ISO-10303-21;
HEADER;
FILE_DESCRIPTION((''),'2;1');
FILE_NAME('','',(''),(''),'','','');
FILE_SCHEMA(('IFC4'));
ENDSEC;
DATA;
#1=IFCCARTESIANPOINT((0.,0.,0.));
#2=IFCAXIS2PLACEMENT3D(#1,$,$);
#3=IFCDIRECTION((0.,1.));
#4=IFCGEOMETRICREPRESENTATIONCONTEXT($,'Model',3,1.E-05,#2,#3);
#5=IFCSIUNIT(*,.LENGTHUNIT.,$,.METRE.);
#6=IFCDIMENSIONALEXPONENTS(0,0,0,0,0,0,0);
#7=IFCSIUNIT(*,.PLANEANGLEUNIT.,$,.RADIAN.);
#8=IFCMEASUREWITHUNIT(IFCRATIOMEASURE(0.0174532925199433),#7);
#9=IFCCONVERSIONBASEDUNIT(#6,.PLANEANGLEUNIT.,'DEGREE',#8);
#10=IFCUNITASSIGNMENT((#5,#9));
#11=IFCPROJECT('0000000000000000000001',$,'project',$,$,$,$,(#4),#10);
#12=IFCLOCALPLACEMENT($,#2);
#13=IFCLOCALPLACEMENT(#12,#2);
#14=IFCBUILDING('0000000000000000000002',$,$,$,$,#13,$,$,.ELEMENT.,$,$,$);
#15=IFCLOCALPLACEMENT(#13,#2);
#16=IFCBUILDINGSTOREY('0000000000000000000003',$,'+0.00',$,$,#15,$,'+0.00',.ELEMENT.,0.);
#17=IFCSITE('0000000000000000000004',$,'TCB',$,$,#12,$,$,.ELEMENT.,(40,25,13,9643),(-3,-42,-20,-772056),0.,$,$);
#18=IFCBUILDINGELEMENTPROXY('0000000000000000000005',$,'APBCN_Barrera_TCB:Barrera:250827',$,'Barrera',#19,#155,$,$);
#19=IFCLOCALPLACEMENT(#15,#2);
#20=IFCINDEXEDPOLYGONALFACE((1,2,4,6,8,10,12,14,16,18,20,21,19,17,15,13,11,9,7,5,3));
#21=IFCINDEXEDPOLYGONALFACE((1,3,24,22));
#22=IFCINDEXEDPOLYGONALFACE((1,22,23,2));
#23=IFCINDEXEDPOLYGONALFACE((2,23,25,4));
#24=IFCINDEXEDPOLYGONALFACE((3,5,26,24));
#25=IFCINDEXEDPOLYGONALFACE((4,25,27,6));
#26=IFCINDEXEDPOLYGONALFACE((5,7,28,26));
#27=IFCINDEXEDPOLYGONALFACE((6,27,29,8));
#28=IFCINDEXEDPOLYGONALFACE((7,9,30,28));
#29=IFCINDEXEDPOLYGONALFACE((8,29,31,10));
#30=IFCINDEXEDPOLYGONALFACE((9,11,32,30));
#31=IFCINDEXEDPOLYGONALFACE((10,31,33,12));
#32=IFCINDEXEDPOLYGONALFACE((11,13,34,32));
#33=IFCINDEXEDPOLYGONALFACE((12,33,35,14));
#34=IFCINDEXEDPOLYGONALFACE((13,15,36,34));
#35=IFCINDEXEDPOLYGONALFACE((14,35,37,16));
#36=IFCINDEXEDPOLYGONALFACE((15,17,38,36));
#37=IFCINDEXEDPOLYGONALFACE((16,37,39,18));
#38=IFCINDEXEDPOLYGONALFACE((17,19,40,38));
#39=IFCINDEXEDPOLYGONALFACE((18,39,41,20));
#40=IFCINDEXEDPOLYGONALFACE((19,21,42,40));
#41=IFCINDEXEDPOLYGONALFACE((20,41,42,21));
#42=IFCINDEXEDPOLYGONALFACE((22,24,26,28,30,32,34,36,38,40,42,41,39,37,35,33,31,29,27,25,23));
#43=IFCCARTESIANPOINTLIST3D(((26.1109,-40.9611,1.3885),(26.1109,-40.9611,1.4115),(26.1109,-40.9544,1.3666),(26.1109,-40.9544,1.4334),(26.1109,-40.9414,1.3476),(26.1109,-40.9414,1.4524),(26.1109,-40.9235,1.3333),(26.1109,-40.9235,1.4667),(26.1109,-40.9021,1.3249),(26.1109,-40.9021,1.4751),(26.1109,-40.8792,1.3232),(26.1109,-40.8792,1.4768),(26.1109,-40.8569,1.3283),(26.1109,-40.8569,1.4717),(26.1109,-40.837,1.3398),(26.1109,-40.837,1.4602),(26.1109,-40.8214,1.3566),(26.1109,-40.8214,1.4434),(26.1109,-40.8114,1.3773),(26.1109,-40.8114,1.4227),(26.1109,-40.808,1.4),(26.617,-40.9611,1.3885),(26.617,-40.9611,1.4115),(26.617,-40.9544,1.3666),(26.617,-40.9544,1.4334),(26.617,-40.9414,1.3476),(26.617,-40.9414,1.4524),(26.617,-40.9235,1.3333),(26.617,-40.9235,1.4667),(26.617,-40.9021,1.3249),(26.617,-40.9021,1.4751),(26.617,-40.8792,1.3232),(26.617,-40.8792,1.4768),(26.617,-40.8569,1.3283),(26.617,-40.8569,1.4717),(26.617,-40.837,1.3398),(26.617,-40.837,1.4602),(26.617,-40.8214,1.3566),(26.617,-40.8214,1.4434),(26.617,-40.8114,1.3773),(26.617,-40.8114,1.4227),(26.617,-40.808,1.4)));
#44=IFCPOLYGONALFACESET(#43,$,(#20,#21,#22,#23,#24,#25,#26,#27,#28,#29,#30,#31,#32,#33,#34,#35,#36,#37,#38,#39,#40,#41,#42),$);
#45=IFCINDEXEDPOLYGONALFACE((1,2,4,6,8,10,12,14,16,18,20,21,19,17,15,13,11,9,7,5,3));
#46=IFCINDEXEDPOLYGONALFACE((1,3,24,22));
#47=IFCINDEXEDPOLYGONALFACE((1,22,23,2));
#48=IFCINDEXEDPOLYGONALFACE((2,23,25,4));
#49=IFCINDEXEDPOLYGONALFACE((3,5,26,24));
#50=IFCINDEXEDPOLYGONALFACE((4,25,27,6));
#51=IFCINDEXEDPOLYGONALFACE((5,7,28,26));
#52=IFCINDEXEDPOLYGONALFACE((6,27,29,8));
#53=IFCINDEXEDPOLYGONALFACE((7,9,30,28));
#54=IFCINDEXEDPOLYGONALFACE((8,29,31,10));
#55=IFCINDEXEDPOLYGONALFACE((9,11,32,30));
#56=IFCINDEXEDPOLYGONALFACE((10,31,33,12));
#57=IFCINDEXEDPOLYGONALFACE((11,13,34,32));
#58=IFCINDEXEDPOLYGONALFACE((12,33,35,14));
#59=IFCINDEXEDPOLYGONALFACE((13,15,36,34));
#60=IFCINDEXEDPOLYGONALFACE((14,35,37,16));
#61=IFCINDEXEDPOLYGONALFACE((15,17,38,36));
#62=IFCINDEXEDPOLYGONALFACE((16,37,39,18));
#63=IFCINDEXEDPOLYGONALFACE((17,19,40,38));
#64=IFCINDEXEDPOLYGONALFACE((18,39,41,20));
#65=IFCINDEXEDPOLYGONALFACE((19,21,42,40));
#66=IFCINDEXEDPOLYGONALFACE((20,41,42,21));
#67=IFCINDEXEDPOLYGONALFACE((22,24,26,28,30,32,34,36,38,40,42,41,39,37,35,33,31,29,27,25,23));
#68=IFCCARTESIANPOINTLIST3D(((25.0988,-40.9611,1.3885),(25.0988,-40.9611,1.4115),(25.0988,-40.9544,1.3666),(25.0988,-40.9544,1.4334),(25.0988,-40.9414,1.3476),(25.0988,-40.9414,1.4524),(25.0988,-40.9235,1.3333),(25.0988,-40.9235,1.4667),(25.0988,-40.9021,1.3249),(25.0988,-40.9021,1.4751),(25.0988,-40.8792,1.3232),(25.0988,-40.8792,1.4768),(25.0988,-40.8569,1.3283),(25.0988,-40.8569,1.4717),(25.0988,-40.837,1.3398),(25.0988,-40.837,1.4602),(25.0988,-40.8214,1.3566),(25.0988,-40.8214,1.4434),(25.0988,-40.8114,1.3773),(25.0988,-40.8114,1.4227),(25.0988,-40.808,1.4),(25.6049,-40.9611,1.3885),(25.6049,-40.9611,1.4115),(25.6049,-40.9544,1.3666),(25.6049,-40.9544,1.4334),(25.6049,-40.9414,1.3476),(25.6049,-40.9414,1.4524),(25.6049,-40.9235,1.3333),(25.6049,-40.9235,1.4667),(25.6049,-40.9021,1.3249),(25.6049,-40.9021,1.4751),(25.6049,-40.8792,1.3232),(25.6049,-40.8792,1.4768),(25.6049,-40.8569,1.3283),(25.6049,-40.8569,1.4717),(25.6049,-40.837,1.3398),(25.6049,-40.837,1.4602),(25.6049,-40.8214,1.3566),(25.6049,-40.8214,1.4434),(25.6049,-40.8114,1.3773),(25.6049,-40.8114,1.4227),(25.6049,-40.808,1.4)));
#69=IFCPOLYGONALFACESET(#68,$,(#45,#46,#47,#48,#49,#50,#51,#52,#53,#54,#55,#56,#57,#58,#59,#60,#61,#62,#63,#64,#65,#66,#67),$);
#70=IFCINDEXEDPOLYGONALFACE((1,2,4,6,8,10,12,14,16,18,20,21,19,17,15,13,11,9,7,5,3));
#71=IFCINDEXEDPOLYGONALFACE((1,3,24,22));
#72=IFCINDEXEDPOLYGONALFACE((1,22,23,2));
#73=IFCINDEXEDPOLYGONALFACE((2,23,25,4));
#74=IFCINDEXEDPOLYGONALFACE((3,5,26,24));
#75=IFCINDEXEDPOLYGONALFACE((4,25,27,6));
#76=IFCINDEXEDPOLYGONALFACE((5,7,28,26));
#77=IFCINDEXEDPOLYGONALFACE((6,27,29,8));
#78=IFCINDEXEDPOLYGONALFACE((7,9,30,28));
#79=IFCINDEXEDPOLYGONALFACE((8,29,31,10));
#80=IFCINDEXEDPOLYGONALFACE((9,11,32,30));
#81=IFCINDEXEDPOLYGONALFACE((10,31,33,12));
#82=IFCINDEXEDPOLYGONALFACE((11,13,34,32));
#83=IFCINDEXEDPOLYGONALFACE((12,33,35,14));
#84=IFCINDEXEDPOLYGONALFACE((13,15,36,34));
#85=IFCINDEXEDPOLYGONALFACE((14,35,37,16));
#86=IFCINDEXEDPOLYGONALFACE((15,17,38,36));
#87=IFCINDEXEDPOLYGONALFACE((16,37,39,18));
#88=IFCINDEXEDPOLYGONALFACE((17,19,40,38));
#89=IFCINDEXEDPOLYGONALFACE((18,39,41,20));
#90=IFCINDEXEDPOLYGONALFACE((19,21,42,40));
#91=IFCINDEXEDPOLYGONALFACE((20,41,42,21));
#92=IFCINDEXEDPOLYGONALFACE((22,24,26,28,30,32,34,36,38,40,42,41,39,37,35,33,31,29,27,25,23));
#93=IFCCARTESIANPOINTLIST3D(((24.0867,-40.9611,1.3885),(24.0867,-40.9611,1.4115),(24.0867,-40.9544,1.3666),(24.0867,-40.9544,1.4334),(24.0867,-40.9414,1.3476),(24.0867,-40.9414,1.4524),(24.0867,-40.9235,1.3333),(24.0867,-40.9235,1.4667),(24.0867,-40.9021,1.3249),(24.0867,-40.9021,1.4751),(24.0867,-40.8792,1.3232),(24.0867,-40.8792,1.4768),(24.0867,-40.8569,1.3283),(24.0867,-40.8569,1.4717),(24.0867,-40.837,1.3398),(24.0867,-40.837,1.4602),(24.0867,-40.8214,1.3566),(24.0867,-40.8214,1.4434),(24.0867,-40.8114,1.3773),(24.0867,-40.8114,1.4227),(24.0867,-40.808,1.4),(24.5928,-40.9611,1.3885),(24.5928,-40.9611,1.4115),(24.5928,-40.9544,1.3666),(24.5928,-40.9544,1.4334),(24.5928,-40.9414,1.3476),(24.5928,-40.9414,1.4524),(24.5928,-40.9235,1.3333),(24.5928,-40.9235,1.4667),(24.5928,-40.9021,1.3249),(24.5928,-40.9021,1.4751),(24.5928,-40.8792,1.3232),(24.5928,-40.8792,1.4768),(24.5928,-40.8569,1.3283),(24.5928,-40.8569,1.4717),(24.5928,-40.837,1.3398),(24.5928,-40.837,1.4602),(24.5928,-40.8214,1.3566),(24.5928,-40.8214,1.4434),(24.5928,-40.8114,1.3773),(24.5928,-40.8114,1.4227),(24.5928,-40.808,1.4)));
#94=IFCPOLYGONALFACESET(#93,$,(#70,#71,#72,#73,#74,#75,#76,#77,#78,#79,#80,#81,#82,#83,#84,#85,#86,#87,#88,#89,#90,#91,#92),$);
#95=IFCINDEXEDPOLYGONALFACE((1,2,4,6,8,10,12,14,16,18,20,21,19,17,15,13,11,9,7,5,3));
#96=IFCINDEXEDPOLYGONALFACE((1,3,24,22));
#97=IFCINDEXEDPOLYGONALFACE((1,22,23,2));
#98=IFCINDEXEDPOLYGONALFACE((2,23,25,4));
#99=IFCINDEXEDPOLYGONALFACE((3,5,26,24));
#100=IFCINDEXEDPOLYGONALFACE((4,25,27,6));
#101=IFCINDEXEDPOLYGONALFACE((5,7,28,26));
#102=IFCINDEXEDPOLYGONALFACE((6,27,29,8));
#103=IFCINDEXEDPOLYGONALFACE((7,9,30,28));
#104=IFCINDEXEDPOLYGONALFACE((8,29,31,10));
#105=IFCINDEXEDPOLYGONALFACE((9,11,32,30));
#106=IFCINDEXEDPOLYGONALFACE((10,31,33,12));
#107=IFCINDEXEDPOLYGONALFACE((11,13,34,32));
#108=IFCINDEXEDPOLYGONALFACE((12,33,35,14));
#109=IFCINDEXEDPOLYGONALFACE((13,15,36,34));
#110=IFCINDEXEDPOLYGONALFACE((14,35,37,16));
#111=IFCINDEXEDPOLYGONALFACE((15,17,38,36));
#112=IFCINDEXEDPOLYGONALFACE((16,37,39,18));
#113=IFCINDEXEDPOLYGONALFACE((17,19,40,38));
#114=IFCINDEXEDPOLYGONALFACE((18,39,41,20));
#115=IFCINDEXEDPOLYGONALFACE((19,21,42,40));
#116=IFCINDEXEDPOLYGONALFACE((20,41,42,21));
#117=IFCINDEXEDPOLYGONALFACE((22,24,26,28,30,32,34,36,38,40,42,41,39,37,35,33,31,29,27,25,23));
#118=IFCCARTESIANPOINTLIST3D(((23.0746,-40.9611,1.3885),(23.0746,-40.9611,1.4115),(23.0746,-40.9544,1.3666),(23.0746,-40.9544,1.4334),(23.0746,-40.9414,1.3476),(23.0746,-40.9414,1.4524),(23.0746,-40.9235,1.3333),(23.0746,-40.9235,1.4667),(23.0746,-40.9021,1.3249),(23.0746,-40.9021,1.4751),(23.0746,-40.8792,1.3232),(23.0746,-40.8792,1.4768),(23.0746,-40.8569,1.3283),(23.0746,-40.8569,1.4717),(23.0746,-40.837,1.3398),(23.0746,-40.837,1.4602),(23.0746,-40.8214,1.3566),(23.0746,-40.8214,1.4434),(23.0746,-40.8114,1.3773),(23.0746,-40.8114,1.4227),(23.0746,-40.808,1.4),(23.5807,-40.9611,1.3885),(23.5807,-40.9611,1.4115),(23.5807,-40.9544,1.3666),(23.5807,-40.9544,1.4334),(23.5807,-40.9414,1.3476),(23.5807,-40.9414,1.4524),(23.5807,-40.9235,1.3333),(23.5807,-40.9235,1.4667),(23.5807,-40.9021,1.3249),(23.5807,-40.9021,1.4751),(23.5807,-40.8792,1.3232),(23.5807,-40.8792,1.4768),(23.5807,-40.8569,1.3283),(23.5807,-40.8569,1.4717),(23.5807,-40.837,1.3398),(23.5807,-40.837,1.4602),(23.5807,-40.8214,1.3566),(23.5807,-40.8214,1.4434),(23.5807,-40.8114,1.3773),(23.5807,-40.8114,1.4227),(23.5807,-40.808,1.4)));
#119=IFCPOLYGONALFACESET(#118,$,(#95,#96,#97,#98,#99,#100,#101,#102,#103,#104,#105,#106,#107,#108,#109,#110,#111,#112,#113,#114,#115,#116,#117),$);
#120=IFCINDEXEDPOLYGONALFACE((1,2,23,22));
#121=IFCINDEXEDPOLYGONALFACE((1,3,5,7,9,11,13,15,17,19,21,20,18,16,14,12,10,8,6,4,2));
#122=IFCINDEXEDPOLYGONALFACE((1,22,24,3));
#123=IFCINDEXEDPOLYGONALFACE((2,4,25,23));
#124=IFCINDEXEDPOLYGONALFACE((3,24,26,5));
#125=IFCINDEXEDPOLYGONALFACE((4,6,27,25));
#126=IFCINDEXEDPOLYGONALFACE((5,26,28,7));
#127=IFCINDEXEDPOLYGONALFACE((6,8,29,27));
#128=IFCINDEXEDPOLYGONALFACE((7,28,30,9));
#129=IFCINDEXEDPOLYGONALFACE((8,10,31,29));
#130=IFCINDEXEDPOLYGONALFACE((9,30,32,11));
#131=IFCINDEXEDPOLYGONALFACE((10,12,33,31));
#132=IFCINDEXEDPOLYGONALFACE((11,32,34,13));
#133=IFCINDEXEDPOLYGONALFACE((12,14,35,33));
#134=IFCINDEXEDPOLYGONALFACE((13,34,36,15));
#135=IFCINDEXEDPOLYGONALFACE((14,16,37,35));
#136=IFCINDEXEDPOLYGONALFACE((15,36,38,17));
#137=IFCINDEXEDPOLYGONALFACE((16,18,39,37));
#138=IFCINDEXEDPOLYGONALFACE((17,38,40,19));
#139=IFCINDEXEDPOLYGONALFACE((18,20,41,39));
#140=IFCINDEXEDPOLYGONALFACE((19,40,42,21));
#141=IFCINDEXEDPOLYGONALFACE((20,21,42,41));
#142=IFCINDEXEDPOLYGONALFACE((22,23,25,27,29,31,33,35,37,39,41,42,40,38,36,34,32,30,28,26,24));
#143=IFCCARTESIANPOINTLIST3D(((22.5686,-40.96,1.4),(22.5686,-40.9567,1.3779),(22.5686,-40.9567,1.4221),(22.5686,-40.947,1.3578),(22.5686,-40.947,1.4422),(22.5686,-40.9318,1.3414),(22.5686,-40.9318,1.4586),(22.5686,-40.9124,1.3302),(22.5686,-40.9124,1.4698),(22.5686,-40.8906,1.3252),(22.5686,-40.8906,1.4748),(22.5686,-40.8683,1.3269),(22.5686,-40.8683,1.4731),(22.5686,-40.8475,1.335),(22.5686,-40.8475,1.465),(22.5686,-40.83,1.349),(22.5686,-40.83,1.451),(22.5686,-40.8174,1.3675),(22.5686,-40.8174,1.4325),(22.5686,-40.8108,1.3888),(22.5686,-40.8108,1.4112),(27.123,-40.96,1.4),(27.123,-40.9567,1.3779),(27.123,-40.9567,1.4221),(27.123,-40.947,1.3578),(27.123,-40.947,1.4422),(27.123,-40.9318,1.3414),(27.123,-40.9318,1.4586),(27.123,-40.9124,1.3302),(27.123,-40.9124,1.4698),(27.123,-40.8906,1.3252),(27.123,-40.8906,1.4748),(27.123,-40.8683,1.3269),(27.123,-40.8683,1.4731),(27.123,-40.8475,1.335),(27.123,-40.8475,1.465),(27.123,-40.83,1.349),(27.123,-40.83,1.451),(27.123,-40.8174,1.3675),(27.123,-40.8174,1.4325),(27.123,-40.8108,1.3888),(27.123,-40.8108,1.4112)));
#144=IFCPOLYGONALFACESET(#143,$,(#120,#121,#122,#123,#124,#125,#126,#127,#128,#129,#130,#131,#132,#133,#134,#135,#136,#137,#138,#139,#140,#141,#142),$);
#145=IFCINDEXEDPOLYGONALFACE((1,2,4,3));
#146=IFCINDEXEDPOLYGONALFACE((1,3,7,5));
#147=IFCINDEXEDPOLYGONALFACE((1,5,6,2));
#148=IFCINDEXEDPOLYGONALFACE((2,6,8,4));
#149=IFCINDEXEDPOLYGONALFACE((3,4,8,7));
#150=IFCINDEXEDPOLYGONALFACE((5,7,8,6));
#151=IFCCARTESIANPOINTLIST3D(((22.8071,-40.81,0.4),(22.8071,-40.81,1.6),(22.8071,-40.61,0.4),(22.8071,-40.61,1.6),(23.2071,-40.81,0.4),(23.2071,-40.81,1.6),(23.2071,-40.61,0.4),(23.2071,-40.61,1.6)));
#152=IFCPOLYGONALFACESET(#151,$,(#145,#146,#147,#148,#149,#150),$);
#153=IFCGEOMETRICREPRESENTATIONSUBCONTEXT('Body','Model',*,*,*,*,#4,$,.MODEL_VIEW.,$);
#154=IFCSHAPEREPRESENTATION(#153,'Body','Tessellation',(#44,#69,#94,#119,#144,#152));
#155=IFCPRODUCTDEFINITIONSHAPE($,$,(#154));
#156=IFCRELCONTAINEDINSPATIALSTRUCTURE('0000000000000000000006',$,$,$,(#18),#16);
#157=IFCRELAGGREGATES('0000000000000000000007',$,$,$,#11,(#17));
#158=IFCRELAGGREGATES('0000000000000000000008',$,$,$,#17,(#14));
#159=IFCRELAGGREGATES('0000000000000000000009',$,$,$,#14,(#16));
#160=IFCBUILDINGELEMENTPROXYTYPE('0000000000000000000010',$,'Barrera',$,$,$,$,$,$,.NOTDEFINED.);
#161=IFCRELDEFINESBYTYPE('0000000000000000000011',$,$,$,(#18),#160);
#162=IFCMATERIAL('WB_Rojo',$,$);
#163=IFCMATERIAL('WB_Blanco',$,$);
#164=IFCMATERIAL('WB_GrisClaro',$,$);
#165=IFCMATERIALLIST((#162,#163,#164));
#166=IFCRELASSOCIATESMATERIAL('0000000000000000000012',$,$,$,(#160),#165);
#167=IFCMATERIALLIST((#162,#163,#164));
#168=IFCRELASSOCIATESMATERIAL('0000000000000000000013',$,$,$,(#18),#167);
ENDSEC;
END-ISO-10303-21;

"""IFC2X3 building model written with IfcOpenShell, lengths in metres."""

from ifc_helpers import new_model, entity, si_unit, converted_unit, direction, frame, frame_2d, origin, place, context, subcontext, project, spatial, rectangle, circle, extrude, source, transform, mapped, material, material_list, type_object, type_shapes, element, save


model = new_model("IFC2X3")

# Units and contexts
model_context = context("Model", 3, precision=1e-05, world=origin(), true_north=direction((0.0, 1.0)))
body_context = subcontext(model_context, "Body", "Model", "MODEL_VIEW")
ifc_project = project(units=[si_unit("LENGTHUNIT", "METRE"), converted_unit("PLANEANGLEUNIT", "DEGREE", entity("IfcRatioMeasure", 0.0174532925199433), si_unit("PLANEANGLEUNIT", "RADIAN"), dimensions=[0, 0, 0, 0, 0, 0, 0])], contexts=[model_context])

# Site, building, storey
site_placement = place(None, origin())
site = spatial("IfcSite", under=ifc_project, at=site_placement, Name="TCB", CompositionType="ELEMENT", RefLatitude=(40, 25, 13, 9643), RefLongitude=(-3, -42, -20, -772056), RefElevation=0.0)
building_placement = place(site_placement, origin())
building = spatial("IfcBuilding", under=site, at=building_placement, CompositionType="ELEMENT")
storey_placement = place(building_placement, origin())
storey = spatial("IfcBuildingStorey", under=building, at=storey_placement, Name="+0.00", LongName="+0.00", CompositionType="ELEMENT", Elevation=0.0)

# Shared definitions
ifc_material_1 = material(Name="WB_Blanco")

# Shared definitions
ifc_material_2 = material(Name="WB_GrisClaro")

# Building element proxy
ifc_material_3 = material(Name="WB_Rojo")
ifc_material_list_1 = material_list([ifc_material_3, ifc_material_1, ifc_material_2])
building_element_proxy_type_1 = type_object("IfcBuildingElementProxyType", Name="Barrera", PredefinedType="NOTDEFINED", material=ifc_material_list_1)
shared_shape_1 = source(origin(), body_context, "Body", "SweptSolid", [
    extrude(circle(Radius=0.077, at=frame_2d((0.0, 0.0), x_axis=(1.0, 0.0))), frame((2.8039, -0.175, 1.0), z_axis=(1.0, 0.0, 0.0), x_axis=(0.0, 1.0, 0.0)), (0.0, 0.0, 1.0), 0.506),
    extrude(circle(Radius=0.077, at=frame_2d((0.0, 0.0), x_axis=(1.0, 0.0))), frame((1.7918, -0.175, 1.0), z_axis=(1.0, 0.0, 0.0), x_axis=(0.0, 1.0, 0.0)), (0.0, 0.0, 1.0), 0.506),
    extrude(circle(Radius=0.077, at=frame_2d((0.0, 0.0), x_axis=(1.0, 0.0))), frame((0.7797, -0.175, 1.0), z_axis=(1.0, 0.0, 0.0), x_axis=(0.0, 1.0, 0.0)), (0.0, 0.0, 1.0), 0.506),
    extrude(circle(Radius=0.077, at=frame_2d((0.0, 0.0), x_axis=(1.0, 0.0))), frame((-0.2324, -0.175, 1.0), z_axis=(1.0, 0.0, 0.0), x_axis=(0.0, 1.0, 0.0)), (0.0, 0.0, 1.0), 0.506),
    extrude(circle(Radius=0.075, at=frame_2d((0.0, 0.0), x_axis=(1.0, 0.0))), frame((-0.7385, -0.175, 1.0), z_axis=(1.0, 0.0, 0.0), x_axis=(0.0, -1.0, 0.0)), (0.0, 0.0, 1.0), 4.5544),
    extrude(rectangle(XDim=0.2, YDim=0.4, at=frame_2d((0.0, 0.0), x_axis=(1.0, 0.0))), frame((-0.3, 0.0, 0.0), z_axis=(0.0, 0.0, 1.0), x_axis=(0.0, -1.0, 0.0)), (0.0, 0.0, 1.0), 1.2),
])
type_shapes(building_element_proxy_type_1, [shared_shape_1])
ifc_material_list_2 = material_list([ifc_material_3, ifc_material_1, ifc_material_2])
proxy_1_placement = place(storey_placement, frame((23.3071, -40.71, 0.4)))
element("IfcBuildingElementProxy", 1, at=proxy_1_placement, inside=storey, type_object=building_element_proxy_type_1, material=ifc_material_list_2, Name="APBCN_Barrera_TCB:Barrera:250827", ObjectType="Barrera", context=body_context, shape_type="MappedRepresentation", body=[
    mapped(shared_shape_1, transform((0.0, 0.0, 0.0), scale=1.0)),
])

save(model, "model.ifc")
